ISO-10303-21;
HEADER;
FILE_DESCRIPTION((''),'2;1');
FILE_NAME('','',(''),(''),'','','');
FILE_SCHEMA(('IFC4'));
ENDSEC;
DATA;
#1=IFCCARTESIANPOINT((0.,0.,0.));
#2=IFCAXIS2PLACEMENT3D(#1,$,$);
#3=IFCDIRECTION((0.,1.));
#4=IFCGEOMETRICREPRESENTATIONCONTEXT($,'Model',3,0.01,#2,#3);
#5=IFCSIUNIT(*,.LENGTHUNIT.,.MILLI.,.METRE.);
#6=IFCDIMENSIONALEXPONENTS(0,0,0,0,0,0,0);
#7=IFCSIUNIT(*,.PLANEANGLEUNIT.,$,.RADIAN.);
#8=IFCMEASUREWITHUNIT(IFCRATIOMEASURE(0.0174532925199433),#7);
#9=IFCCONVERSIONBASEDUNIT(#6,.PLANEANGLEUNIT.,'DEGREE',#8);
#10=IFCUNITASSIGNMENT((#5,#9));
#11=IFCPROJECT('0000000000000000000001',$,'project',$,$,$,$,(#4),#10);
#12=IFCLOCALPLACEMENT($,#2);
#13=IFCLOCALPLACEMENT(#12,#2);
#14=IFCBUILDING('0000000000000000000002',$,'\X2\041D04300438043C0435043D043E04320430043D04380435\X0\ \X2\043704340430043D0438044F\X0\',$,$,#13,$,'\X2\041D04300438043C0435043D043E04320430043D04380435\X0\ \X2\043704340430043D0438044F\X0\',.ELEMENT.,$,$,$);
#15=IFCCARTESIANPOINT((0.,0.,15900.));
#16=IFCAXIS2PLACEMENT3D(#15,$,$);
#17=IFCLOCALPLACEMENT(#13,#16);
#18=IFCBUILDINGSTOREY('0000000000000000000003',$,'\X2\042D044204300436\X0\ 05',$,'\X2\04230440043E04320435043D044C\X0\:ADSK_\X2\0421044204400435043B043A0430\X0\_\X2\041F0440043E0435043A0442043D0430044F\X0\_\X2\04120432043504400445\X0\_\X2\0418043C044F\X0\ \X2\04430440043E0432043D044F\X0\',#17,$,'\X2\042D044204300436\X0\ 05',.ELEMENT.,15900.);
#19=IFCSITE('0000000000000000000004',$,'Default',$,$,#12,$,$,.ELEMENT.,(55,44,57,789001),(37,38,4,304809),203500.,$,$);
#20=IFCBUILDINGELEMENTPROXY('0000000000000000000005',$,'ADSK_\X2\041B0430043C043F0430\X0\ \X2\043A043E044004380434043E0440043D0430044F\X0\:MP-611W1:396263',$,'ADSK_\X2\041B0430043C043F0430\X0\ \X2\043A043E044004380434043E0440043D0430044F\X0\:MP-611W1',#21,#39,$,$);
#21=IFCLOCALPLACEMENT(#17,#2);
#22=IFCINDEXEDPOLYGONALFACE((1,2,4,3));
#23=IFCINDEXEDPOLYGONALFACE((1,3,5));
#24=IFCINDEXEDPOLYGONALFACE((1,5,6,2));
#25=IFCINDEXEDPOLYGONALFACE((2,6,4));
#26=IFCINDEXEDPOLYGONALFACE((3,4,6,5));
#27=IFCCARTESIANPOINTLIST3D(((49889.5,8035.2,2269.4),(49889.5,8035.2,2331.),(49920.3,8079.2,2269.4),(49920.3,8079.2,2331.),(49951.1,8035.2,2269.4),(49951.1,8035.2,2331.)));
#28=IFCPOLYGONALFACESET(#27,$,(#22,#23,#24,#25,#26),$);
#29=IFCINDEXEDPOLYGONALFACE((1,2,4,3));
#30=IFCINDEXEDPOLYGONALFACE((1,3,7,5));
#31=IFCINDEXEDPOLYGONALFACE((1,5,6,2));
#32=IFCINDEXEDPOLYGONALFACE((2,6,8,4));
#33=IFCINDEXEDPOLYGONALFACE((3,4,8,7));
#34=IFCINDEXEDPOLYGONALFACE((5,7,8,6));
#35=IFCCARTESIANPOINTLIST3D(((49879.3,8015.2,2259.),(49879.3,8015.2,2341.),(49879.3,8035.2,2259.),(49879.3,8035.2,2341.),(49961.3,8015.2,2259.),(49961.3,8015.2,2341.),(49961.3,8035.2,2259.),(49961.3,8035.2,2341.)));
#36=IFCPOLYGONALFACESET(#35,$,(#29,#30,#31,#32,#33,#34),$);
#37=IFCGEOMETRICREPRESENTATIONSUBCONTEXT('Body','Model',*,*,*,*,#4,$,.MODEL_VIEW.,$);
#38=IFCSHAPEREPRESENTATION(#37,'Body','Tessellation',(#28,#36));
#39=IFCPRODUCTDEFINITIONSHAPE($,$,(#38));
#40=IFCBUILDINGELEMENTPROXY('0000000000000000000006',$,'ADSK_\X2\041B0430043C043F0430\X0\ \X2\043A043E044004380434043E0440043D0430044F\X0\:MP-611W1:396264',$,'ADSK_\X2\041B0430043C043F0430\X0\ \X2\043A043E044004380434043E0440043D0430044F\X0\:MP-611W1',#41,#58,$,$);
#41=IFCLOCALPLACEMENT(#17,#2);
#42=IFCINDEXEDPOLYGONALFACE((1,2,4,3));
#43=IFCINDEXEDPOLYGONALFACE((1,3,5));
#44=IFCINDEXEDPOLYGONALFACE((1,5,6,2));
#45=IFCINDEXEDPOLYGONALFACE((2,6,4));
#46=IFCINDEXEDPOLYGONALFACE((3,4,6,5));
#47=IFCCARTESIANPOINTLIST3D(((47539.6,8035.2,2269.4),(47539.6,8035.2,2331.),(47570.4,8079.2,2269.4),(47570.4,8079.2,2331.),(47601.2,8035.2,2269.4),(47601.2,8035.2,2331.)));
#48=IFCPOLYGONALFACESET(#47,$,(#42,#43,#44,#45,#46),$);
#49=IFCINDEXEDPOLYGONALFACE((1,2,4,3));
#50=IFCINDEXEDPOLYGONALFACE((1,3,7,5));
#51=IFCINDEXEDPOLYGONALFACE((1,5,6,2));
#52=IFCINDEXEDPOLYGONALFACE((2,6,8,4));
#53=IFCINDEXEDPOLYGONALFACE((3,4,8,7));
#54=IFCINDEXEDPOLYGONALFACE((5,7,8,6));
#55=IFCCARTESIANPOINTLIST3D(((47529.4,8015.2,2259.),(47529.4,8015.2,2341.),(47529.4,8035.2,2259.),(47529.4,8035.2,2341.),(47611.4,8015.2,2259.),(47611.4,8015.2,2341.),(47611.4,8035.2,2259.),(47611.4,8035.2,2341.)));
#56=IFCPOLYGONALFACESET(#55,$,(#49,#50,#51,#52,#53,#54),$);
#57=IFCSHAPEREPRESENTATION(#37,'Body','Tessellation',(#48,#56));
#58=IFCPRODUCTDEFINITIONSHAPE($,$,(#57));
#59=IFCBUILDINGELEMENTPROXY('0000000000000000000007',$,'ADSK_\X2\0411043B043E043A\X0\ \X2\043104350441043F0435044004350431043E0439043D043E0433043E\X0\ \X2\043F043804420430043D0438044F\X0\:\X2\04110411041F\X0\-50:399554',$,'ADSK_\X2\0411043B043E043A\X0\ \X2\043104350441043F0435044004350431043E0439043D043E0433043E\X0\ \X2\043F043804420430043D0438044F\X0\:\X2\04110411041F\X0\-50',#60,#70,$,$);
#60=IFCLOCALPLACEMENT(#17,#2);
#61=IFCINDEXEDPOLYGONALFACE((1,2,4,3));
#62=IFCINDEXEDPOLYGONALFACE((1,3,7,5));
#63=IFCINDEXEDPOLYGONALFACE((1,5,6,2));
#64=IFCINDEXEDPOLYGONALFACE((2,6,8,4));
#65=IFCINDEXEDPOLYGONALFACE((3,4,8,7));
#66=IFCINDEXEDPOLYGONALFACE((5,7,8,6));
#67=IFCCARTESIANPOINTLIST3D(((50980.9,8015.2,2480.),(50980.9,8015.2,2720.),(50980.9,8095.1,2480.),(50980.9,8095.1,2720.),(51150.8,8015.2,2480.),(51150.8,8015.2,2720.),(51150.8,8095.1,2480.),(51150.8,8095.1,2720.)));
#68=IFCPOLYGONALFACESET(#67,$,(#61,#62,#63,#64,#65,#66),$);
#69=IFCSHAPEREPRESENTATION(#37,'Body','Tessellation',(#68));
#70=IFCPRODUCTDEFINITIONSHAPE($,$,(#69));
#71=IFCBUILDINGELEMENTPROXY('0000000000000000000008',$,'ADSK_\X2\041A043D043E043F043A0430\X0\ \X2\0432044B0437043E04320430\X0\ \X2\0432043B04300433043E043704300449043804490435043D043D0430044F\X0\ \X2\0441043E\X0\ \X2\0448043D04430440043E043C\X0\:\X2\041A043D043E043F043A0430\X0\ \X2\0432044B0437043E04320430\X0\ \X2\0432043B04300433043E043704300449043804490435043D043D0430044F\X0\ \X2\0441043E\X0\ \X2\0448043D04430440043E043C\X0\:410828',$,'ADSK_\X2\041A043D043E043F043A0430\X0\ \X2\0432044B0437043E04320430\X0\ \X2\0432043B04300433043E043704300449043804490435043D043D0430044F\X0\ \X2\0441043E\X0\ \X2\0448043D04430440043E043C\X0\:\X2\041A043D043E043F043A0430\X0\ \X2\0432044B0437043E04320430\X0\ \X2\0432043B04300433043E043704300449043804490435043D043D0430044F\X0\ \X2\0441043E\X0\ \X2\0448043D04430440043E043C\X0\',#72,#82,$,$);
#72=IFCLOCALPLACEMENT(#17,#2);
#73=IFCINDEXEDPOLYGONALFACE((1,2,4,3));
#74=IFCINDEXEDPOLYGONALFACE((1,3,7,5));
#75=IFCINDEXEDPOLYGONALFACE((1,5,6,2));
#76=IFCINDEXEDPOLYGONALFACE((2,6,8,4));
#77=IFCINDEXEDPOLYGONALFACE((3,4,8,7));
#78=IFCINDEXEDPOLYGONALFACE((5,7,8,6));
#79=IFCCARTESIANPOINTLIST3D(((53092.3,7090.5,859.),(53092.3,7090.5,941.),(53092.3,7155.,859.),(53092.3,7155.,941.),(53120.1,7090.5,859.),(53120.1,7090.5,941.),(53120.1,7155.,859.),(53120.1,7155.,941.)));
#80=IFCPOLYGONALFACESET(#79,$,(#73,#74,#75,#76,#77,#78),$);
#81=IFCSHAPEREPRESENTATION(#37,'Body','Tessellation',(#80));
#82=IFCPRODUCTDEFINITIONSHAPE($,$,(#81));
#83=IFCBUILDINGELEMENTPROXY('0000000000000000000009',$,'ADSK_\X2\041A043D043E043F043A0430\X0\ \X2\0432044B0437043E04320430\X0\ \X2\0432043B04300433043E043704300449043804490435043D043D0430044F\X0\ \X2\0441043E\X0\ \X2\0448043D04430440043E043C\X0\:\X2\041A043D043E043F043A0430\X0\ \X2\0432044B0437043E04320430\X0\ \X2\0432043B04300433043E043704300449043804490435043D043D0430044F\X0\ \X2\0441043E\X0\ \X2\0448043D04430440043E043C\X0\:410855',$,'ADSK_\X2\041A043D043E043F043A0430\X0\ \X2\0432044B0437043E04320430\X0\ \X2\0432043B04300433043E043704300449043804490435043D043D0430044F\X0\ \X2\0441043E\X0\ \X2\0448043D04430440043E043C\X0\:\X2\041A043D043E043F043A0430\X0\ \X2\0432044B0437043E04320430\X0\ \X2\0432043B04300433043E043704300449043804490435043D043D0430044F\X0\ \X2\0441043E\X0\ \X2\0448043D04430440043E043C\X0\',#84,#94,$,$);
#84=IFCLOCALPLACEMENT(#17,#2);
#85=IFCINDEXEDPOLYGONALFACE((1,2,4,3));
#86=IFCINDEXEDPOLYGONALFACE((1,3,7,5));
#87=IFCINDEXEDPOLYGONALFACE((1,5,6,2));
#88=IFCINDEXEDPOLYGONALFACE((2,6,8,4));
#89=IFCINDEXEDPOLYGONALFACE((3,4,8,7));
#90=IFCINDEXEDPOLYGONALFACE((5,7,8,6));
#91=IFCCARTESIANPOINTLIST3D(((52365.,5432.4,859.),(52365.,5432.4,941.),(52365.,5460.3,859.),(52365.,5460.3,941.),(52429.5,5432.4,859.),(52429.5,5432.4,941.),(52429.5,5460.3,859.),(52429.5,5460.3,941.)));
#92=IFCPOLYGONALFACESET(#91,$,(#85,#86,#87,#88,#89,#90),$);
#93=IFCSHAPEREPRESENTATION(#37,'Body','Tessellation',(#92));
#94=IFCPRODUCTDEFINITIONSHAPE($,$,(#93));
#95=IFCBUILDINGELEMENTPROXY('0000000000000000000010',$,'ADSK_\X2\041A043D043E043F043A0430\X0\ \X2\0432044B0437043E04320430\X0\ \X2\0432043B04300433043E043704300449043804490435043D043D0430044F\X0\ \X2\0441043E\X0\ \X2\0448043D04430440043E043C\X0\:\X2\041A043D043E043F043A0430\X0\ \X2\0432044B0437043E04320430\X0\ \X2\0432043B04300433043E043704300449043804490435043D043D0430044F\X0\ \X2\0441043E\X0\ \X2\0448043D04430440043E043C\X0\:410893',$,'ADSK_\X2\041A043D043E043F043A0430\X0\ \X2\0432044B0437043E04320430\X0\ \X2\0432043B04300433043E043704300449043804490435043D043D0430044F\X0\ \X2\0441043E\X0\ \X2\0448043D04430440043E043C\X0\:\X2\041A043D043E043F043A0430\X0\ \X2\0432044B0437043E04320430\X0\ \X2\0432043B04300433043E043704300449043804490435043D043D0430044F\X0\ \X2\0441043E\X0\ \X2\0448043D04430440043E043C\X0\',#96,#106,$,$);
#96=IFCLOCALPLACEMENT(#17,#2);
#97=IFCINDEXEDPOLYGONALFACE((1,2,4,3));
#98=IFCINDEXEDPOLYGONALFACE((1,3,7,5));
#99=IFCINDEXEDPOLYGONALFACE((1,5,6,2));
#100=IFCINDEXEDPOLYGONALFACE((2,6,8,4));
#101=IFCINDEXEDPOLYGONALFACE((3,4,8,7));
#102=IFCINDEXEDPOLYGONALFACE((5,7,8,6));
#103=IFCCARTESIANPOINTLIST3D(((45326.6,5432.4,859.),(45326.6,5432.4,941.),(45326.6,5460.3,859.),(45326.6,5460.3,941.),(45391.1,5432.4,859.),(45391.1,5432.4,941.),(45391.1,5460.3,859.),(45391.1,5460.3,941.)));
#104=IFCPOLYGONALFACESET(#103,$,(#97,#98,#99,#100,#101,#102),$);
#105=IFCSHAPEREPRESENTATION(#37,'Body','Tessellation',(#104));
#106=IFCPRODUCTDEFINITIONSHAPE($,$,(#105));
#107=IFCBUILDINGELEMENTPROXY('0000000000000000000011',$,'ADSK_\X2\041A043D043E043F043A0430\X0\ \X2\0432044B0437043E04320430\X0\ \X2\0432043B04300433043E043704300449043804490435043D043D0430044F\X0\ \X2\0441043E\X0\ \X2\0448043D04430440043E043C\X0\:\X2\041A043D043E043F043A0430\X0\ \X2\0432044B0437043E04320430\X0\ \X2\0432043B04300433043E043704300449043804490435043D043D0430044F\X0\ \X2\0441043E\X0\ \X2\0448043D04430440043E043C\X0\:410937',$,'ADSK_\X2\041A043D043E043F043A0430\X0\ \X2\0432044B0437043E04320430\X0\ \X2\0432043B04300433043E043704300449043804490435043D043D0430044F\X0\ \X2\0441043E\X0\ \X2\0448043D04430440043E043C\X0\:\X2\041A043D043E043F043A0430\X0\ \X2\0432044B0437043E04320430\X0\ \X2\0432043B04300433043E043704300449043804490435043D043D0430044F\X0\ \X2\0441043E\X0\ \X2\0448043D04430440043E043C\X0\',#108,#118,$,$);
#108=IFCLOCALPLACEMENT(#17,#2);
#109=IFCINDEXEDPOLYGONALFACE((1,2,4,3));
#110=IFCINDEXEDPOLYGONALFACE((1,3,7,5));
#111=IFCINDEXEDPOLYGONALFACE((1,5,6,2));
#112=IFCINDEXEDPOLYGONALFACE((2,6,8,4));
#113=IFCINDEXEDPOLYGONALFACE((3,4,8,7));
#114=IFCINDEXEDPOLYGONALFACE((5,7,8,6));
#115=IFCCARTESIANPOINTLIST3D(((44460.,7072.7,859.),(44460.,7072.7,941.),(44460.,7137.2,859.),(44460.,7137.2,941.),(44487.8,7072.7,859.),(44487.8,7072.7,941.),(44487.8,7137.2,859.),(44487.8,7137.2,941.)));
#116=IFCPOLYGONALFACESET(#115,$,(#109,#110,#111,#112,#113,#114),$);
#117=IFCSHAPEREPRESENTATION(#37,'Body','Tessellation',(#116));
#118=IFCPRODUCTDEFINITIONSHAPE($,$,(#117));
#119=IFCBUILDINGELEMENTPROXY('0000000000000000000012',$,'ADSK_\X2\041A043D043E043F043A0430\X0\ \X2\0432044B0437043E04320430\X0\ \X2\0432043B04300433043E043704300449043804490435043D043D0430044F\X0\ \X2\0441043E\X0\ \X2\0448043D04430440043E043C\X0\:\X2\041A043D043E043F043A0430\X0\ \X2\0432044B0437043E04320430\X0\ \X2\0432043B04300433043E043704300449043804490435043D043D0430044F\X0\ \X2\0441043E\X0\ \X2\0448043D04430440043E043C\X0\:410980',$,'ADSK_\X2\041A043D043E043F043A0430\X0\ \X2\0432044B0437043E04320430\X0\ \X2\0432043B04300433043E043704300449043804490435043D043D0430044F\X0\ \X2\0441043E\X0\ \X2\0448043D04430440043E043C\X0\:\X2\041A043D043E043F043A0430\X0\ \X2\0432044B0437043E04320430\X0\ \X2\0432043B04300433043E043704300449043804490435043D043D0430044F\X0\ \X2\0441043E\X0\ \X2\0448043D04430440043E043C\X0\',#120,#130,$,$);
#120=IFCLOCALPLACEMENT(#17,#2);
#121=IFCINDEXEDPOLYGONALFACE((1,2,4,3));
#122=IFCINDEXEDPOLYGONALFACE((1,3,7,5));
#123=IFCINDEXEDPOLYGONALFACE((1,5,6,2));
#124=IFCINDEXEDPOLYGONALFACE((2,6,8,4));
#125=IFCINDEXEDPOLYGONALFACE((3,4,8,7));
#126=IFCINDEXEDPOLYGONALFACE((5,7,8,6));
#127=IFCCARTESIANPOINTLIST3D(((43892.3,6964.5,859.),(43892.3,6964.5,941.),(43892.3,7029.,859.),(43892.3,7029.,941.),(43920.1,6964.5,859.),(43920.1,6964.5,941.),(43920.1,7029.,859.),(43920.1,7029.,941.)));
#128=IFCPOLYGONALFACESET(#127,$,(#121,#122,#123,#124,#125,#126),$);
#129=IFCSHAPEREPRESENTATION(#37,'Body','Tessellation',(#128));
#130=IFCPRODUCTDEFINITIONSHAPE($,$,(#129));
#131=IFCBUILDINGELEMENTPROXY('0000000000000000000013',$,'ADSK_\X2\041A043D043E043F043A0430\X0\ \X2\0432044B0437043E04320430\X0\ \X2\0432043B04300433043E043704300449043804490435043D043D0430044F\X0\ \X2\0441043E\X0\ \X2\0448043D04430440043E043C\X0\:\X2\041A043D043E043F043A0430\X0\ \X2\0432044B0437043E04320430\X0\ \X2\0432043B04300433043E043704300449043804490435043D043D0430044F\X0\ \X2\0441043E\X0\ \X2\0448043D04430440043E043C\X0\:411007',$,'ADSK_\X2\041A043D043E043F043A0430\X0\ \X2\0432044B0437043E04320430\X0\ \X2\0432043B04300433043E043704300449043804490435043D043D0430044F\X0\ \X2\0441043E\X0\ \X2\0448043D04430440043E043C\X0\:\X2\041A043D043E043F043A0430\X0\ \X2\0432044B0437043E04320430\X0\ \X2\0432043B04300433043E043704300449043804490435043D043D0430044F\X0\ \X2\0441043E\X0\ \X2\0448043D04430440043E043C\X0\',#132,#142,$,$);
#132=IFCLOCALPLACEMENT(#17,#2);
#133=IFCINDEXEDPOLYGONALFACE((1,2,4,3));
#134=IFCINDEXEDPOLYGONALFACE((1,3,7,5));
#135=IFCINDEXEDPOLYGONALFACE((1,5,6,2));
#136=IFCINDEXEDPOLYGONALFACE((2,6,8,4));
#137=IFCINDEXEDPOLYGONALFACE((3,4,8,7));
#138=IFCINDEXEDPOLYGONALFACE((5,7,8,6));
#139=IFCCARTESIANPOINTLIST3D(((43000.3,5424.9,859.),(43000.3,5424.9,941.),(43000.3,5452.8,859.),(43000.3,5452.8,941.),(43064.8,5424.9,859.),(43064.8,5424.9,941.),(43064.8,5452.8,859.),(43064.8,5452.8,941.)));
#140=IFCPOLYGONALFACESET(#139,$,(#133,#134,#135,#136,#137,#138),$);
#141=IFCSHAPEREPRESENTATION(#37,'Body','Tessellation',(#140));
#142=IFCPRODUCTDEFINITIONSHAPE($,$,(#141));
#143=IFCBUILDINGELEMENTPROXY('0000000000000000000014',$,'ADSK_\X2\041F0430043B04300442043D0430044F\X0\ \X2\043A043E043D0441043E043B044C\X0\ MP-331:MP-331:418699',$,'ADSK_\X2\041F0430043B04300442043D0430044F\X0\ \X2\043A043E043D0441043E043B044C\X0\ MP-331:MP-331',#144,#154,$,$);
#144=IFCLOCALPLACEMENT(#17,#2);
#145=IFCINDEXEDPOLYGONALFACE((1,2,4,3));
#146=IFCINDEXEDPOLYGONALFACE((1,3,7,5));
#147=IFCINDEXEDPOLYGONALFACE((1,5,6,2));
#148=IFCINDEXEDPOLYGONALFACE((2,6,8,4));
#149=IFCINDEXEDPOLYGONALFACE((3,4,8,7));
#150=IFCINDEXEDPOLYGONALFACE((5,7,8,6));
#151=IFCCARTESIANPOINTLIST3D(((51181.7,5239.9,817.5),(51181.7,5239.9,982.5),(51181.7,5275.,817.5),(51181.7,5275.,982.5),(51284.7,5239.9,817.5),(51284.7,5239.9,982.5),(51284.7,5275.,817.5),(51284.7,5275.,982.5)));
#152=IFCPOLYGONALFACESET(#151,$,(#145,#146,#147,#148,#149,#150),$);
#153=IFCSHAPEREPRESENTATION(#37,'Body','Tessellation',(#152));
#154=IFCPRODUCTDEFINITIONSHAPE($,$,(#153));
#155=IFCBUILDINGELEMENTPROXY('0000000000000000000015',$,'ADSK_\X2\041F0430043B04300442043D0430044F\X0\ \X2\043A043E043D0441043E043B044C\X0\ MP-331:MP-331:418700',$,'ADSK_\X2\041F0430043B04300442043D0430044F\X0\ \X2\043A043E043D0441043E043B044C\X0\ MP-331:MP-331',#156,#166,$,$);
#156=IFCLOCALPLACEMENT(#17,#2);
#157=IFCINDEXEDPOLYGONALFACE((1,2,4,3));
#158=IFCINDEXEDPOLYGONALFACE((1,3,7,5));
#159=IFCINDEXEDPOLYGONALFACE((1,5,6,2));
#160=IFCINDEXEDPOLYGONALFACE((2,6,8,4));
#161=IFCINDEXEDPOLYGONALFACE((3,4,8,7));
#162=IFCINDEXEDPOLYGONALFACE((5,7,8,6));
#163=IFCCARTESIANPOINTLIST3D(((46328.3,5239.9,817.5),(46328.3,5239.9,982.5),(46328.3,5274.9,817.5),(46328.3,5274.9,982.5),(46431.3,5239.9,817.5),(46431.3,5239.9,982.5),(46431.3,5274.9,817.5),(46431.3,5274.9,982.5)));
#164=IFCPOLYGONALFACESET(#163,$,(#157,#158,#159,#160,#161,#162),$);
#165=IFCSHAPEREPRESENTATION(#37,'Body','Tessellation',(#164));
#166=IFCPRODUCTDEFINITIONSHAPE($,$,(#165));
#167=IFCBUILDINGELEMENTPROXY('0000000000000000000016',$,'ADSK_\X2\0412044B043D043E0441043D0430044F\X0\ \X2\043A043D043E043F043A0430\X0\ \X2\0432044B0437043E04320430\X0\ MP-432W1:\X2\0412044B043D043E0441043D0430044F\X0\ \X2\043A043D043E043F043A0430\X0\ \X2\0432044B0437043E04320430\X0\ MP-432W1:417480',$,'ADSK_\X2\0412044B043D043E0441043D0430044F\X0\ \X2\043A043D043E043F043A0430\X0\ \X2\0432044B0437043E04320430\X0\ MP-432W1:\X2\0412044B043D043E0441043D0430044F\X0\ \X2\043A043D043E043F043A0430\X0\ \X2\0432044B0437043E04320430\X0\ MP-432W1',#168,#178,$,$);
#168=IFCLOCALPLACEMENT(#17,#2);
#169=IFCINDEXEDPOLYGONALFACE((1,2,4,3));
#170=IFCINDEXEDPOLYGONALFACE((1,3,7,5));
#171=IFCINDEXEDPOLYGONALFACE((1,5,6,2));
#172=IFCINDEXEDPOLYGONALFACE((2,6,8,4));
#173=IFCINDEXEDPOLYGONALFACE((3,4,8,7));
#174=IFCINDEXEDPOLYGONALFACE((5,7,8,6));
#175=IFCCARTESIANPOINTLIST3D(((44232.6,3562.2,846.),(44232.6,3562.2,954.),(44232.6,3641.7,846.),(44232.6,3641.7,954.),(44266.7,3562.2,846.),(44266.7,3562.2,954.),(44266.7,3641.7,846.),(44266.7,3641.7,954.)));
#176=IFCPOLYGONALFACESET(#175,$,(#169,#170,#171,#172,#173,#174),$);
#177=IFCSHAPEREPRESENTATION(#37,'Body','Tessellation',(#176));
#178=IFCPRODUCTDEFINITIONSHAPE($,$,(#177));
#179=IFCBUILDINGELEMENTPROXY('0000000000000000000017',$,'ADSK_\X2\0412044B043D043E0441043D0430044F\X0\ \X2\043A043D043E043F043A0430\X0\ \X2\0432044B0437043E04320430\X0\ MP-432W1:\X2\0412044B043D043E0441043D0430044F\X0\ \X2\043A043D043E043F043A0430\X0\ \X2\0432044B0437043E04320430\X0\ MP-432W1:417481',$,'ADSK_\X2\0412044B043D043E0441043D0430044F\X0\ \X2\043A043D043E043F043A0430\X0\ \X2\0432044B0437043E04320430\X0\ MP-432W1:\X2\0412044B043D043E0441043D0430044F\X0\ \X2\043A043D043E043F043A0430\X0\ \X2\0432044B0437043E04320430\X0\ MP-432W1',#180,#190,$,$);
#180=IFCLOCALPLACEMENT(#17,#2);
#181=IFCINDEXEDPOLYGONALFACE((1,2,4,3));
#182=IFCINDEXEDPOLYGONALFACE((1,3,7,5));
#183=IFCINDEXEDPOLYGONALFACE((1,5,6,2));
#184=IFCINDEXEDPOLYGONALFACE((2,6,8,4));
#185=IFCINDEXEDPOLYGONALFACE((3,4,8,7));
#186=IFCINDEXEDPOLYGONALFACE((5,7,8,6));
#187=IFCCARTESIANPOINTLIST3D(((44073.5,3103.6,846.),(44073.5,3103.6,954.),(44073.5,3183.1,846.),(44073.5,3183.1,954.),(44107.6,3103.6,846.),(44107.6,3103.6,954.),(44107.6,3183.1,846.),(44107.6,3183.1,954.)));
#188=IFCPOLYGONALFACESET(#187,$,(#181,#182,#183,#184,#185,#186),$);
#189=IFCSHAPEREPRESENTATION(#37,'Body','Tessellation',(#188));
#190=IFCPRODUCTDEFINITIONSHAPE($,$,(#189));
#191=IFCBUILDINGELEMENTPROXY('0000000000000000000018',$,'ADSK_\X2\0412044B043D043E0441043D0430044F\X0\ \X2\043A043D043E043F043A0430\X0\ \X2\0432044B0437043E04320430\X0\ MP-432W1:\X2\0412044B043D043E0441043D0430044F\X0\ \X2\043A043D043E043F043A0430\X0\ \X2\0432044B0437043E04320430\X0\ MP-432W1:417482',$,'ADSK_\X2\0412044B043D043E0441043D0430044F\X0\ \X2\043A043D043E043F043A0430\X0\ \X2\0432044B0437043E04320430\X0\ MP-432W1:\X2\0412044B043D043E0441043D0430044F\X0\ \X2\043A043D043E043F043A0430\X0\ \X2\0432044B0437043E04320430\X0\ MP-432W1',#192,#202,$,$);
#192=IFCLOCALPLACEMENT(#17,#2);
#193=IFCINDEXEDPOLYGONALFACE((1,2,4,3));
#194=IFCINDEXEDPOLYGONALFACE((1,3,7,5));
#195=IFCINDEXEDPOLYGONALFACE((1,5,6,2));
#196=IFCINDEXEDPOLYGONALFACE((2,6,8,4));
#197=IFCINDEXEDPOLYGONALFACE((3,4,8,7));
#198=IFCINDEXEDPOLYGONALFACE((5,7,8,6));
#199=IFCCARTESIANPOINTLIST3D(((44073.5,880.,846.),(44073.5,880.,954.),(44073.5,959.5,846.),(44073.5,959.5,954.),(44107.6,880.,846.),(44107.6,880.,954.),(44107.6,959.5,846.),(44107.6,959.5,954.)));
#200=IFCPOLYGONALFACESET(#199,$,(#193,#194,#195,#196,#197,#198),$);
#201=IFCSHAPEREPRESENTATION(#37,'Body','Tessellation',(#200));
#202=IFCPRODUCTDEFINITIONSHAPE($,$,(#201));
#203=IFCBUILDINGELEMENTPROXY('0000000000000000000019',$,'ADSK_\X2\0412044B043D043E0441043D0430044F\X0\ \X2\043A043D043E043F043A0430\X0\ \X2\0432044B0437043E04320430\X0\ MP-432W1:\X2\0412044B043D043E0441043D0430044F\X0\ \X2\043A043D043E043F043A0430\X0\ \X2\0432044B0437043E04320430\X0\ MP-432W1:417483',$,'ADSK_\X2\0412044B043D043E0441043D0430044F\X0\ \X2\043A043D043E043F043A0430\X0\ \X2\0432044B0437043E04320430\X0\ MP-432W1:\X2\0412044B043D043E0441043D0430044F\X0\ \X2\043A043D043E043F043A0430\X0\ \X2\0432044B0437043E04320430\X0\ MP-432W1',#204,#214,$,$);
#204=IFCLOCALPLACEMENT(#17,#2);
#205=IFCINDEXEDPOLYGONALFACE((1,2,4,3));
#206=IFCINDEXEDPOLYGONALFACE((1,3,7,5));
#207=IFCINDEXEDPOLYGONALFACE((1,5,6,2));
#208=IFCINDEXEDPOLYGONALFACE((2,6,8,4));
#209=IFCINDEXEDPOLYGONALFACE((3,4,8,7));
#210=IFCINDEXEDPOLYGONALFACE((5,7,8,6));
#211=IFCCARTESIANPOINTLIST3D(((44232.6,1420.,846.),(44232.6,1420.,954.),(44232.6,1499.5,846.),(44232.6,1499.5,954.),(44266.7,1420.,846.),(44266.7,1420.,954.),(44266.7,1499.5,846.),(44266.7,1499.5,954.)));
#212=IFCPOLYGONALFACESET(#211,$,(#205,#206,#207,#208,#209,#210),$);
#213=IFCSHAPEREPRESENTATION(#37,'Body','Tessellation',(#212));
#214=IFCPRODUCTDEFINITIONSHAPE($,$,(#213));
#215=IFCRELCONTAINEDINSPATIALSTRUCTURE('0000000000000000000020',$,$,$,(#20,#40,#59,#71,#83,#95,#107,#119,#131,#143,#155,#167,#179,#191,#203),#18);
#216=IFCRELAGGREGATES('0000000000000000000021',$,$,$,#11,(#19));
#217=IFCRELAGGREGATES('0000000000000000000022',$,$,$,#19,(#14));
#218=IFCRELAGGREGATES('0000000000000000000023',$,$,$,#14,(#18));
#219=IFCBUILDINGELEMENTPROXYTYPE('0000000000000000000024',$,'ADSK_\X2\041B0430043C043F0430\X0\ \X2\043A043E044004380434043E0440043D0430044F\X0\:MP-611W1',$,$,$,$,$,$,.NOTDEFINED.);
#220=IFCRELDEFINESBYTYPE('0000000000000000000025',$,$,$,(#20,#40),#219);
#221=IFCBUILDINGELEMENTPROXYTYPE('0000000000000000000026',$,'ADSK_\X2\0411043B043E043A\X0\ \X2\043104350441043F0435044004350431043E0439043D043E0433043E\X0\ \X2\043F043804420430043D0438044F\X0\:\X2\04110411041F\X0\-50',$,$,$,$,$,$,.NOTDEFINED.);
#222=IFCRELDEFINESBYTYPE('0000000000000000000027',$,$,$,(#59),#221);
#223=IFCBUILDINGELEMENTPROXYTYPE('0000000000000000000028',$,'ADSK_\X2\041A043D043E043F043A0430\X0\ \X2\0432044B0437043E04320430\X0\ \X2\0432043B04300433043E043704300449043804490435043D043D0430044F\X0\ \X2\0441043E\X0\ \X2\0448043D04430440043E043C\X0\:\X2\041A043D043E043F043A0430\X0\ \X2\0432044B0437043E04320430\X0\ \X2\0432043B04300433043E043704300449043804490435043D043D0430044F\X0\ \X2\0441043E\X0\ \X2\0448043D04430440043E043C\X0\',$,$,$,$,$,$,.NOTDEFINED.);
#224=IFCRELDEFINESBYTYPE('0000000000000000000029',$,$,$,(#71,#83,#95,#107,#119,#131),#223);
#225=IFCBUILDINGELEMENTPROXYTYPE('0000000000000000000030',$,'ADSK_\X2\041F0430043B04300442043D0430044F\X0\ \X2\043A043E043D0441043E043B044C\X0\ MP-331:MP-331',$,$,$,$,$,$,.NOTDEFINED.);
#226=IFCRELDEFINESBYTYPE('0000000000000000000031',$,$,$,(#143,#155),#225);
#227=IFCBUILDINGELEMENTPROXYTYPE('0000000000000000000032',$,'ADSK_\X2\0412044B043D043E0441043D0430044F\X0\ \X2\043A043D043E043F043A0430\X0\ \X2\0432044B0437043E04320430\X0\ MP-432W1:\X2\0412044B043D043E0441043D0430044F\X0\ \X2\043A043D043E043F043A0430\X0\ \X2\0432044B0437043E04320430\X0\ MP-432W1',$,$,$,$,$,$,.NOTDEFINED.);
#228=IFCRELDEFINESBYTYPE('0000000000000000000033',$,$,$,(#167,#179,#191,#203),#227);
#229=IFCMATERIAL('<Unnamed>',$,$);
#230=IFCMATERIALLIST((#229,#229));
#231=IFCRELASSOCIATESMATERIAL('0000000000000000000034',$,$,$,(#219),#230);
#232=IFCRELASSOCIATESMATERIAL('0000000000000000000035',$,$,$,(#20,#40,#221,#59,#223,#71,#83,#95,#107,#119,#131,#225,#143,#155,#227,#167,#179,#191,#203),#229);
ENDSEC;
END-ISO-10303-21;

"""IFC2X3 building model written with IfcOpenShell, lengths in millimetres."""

from ifc_helpers import new_model, entity, si_unit, converted_unit, direction, frame, origin, origin_2d_with_axis, place, context, subcontext, project, spatial, polyline, rectangle, outline, extrude, source, transform, mapped, material, material_list, type_object, type_shapes, element, save


model = new_model("IFC2X3")

# Units and contexts
model_context = context("Model", 3, precision=0.01, world=origin(), true_north=direction((0.0, 1.0)))
body_context = subcontext(model_context, "Body", "Model", "MODEL_VIEW")
ifc_project = project(units=[si_unit("LENGTHUNIT", "METRE", prefix="MILLI"), converted_unit("PLANEANGLEUNIT", "DEGREE", entity("IfcRatioMeasure", 0.0174532925199433), si_unit("PLANEANGLEUNIT", "RADIAN"), dimensions=[0, 0, 0, 0, 0, 0, 0])], contexts=[model_context])

# Site, building, storey
site_placement = place(None, origin())
site = spatial("IfcSite", under=ifc_project, at=site_placement, Name="Default", CompositionType="ELEMENT", RefLatitude=(55, 44, 57, 789001), RefLongitude=(37, 38, 4, 304809), RefElevation=203500.0)
building_placement = place(site_placement, origin())
building = spatial("IfcBuilding", under=site, at=building_placement, Name="Наименование здания", LongName="Наименование здания", CompositionType="ELEMENT")
storey_placement = place(building_placement, frame((0.0, 0.0, 15900.0)))
storey = spatial("IfcBuildingStorey", under=building, at=storey_placement, Name="Этаж 05", ObjectType="Уровень:ADSK_Стрелка_Проектная_Вверх_Имя уровня", LongName="Этаж 05", CompositionType="ELEMENT", Elevation=15900.0)

# Building element proxies
ifc_material = material(Name="<Unnamed>")
ifc_material_list = material_list([ifc_material, ifc_material])
building_element_proxy_type_1 = type_object("IfcBuildingElementProxyType", Name="ADSK_Лампа коридорная:MP-611W1", PredefinedType="NOTDEFINED", material=ifc_material_list)
shared_shape_1 = source(origin(), body_context, "Body", "SweptSolid", [
    extrude(outline(polyline([(-30.8, -14.7), (30.8, -14.7), (0.0, 29.3), (-30.8, -14.7)])), frame((0.0, -2.7, -30.6), z_axis=(0.0, 0.0, 1.0), x_axis=(-1.0, 0.0, 0.0)), (0.0, 0.0, 1.0), 61.6),
    extrude(rectangle(XDim=82.0, YDim=20.0, at=origin_2d_with_axis()), frame((0.0, 22.0, -41.0), z_axis=(0.0, 0.0, 1.0), x_axis=(-1.0, 0.0, 0.0)), (0.0, 0.0, 1.0), 82.0),
])
type_shapes(building_element_proxy_type_1, [shared_shape_1])
for number, where, z_axis, x_axis, name in (
    (1, (49920.3, 8047.1, 2300.0), (0.0, 0.0, 1.0), (-1.0, 0.0, 0.0), "ADSK_Лампа коридорная:MP-611W1:396263"),
    (2, (47570.4, 8047.1, 2300.0), (0.0, 0.0, 1.0), (-1.0, 0.0, 0.0), "ADSK_Лампа коридорная:MP-611W1:396264"),
):
    element("IfcBuildingElementProxy", number, at=place(storey_placement, frame(where, z_axis=z_axis, x_axis=x_axis)), inside=storey, type_object=building_element_proxy_type_1, material=ifc_material, Name=name, ObjectType="ADSK_Лампа коридорная:MP-611W1", context=body_context, shape_type="MappedRepresentation", body=[
        mapped(shared_shape_1, transform((0.0, 0.0, 0.0), scale=1.0)),
    ])
building_element_proxy_type_2 = type_object("IfcBuildingElementProxyType", Name="ADSK_Блок бесперебойного питания:ББП-50", PredefinedType="NOTDEFINED", material=ifc_material)
shared_shape_2 = source(origin(), body_context, "Body", "SweptSolid", [
    extrude(rectangle(XDim=170.0, YDim=80.0, at=origin_2d_with_axis()), frame((0.0, -8.0, -120.0), z_axis=(0.0, 0.0, 1.0), x_axis=(-1.0, 0.0, 0.0)), (0.0, 0.0, 1.0), 240.0),
])
type_shapes(building_element_proxy_type_2, [shared_shape_2])
proxy_1_placement = place(storey_placement, frame((51065.8, 8047.1, 2600.0), z_axis=(0.0, 0.0, 1.0), x_axis=(-1.0, 0.0, 0.0)))
element("IfcBuildingElementProxy", 3, at=proxy_1_placement, inside=storey, type_object=building_element_proxy_type_2, material=ifc_material, Name="ADSK_Блок бесперебойного питания:ББП-50:399554", ObjectType="ADSK_Блок бесперебойного питания:ББП-50", context=body_context, shape_type="MappedRepresentation", body=[
    mapped(shared_shape_2, transform((0.0, 0.0, 0.0), scale=1.0)),
])
building_element_proxy_type_3 = type_object("IfcBuildingElementProxyType", Name="ADSK_Кнопка вызова влагозащищенная со шнуром:Кнопка вызова влагозащищенная со шнуром", PredefinedType="NOTDEFINED", material=ifc_material)
shared_shape_3 = source(origin(), body_context, "Body", "SweptSolid", [
    extrude(rectangle(XDim=64.5, YDim=27.8, at=origin_2d_with_axis()), frame((32.2, 13.9, 0.0), z_axis=(0.0, 0.0, 1.0), x_axis=(-1.0, 0.0, 0.0)), (0.0, 0.0, 1.0), 82.0),
])
type_shapes(building_element_proxy_type_3, [shared_shape_3])
for number, where, z_axis, x_axis, name in (
    (4, (53092.3, 7155.0, 859.0), (0.0, 0.0, 1.0), (0.0, -1.0, 0.0), "ADSK_Кнопка вызова влагозащищенная со шнуром:Кнопка вызова влагозащищенная со шнуром:410828"),
    (5, (52429.5, 5460.3, 859.0), (0.0, 0.0, 1.0), (-1.0, 0.0, 0.0), "ADSK_Кнопка вызова влагозащищенная со шнуром:Кнопка вызова влагозащищенная со шнуром:410855"),
    (6, (45391.1, 5460.3, 859.0), (0.0, 0.0, 1.0), (-1.0, 0.0, 0.0), "ADSK_Кнопка вызова влагозащищенная со шнуром:Кнопка вызова влагозащищенная со шнуром:410893"),
    (7, (44487.8, 7072.8, 859.0), (0.0, 0.0, 1.0), (0.0, 1.0, 0.0), "ADSK_Кнопка вызова влагозащищенная со шнуром:Кнопка вызова влагозащищенная со шнуром:410937"),
    (8, (43892.3, 7029.0, 859.0), (0.0, 0.0, 1.0), (0.0, -1.0, 0.0), "ADSK_Кнопка вызова влагозащищенная со шнуром:Кнопка вызова влагозащищенная со шнуром:410980"),
    (9, (43064.8, 5452.8, 859.0), (0.0, 0.0, 1.0), (-1.0, 0.0, 0.0), "ADSK_Кнопка вызова влагозащищенная со шнуром:Кнопка вызова влагозащищенная со шнуром:411007"),
):
    element("IfcBuildingElementProxy", number, at=place(storey_placement, frame(where, z_axis=z_axis, x_axis=x_axis)), inside=storey, type_object=building_element_proxy_type_3, material=ifc_material, Name=name, ObjectType="ADSK_Кнопка вызова влагозащищенная со шнуром:Кнопка вызова влагозащищенная со шнуром", context=body_context, shape_type="MappedRepresentation", body=[
        mapped(shared_shape_3, transform((0.0, 0.0, 0.0), scale=1.0)),
    ])
building_element_proxy_type_4 = type_object("IfcBuildingElementProxyType", Name="ADSK_Палатная консоль MP-331:MP-331", PredefinedType="NOTDEFINED", material=ifc_material)
shared_shape_4 = source(origin(), body_context, "Body", "SweptSolid", [
    extrude(rectangle(XDim=103.0, YDim=35.0, at=origin_2d_with_axis()), frame((0.0, 14.5, -82.5), z_axis=(0.0, 0.0, 1.0), x_axis=(-1.0, 0.0, 0.0)), (0.0, 0.0, 1.0), 165.0),
])
type_shapes(building_element_proxy_type_4, [shared_shape_4])
for number, where, name in (
    (10, (51233.2, 5242.9, 900.0), "ADSK_Палатная консоль MP-331:MP-331:418699"),
    (11, (46379.8, 5242.9, 900.0), "ADSK_Палатная консоль MP-331:MP-331:418700"),
):
    element("IfcBuildingElementProxy", number, at=place(storey_placement, frame(where)), inside=storey, type_object=building_element_proxy_type_4, material=ifc_material, Name=name, ObjectType="ADSK_Палатная консоль MP-331:MP-331", context=body_context, shape_type="MappedRepresentation", body=[
        mapped(shared_shape_4, transform((0.0, 0.0, 0.0), scale=1.0)),
    ])
building_element_proxy_type_5 = type_object("IfcBuildingElementProxyType", Name="ADSK_Выносная кнопка вызова MP-432W1:Выносная кнопка вызова MP-432W1", PredefinedType="NOTDEFINED", material=ifc_material)
shared_shape_5 = source(origin(), body_context, "Body", "SweptSolid", [
    extrude(rectangle(XDim=79.5, YDim=34.1, at=origin_2d_with_axis()), frame((0.0, 15.0, -54.0), z_axis=(0.0, 0.0, 1.0), x_axis=(-1.0, 0.0, 0.0)), (0.0, 0.0, 1.0), 108.0),
])
type_shapes(building_element_proxy_type_5, [shared_shape_5])
for number, where, z_axis, x_axis, name in (
    (12, (44264.6, 3601.9, 900.0), (0.0, 0.0, 1.0), (0.0, 1.0, 0.0), "ADSK_Выносная кнопка вызова MP-432W1:Выносная кнопка вызова MP-432W1:417480"),
    (13, (44075.6, 3143.3, 900.0), (0.0, 0.0, 1.0), (0.0, -1.0, 0.0), "ADSK_Выносная кнопка вызова MP-432W1:Выносная кнопка вызова MP-432W1:417481"),
    (14, (44075.6, 919.8, 900.0), (0.0, 0.0, 1.0), (0.0, -1.0, 0.0), "ADSK_Выносная кнопка вызова MP-432W1:Выносная кнопка вызова MP-432W1:417482"),
    (15, (44264.6, 1459.8, 900.0), (0.0, 0.0, 1.0), (0.0, 1.0, 0.0), "ADSK_Выносная кнопка вызова MP-432W1:Выносная кнопка вызова MP-432W1:417483"),
):
    element("IfcBuildingElementProxy", number, at=place(storey_placement, frame(where, z_axis=z_axis, x_axis=x_axis)), inside=storey, type_object=building_element_proxy_type_5, material=ifc_material, Name=name, ObjectType="ADSK_Выносная кнопка вызова MP-432W1:Выносная кнопка вызова MP-432W1", context=body_context, shape_type="MappedRepresentation", body=[
        mapped(shared_shape_5, transform((0.0, 0.0, 0.0), scale=1.0)),
    ])

save(model, "model.ifc")
